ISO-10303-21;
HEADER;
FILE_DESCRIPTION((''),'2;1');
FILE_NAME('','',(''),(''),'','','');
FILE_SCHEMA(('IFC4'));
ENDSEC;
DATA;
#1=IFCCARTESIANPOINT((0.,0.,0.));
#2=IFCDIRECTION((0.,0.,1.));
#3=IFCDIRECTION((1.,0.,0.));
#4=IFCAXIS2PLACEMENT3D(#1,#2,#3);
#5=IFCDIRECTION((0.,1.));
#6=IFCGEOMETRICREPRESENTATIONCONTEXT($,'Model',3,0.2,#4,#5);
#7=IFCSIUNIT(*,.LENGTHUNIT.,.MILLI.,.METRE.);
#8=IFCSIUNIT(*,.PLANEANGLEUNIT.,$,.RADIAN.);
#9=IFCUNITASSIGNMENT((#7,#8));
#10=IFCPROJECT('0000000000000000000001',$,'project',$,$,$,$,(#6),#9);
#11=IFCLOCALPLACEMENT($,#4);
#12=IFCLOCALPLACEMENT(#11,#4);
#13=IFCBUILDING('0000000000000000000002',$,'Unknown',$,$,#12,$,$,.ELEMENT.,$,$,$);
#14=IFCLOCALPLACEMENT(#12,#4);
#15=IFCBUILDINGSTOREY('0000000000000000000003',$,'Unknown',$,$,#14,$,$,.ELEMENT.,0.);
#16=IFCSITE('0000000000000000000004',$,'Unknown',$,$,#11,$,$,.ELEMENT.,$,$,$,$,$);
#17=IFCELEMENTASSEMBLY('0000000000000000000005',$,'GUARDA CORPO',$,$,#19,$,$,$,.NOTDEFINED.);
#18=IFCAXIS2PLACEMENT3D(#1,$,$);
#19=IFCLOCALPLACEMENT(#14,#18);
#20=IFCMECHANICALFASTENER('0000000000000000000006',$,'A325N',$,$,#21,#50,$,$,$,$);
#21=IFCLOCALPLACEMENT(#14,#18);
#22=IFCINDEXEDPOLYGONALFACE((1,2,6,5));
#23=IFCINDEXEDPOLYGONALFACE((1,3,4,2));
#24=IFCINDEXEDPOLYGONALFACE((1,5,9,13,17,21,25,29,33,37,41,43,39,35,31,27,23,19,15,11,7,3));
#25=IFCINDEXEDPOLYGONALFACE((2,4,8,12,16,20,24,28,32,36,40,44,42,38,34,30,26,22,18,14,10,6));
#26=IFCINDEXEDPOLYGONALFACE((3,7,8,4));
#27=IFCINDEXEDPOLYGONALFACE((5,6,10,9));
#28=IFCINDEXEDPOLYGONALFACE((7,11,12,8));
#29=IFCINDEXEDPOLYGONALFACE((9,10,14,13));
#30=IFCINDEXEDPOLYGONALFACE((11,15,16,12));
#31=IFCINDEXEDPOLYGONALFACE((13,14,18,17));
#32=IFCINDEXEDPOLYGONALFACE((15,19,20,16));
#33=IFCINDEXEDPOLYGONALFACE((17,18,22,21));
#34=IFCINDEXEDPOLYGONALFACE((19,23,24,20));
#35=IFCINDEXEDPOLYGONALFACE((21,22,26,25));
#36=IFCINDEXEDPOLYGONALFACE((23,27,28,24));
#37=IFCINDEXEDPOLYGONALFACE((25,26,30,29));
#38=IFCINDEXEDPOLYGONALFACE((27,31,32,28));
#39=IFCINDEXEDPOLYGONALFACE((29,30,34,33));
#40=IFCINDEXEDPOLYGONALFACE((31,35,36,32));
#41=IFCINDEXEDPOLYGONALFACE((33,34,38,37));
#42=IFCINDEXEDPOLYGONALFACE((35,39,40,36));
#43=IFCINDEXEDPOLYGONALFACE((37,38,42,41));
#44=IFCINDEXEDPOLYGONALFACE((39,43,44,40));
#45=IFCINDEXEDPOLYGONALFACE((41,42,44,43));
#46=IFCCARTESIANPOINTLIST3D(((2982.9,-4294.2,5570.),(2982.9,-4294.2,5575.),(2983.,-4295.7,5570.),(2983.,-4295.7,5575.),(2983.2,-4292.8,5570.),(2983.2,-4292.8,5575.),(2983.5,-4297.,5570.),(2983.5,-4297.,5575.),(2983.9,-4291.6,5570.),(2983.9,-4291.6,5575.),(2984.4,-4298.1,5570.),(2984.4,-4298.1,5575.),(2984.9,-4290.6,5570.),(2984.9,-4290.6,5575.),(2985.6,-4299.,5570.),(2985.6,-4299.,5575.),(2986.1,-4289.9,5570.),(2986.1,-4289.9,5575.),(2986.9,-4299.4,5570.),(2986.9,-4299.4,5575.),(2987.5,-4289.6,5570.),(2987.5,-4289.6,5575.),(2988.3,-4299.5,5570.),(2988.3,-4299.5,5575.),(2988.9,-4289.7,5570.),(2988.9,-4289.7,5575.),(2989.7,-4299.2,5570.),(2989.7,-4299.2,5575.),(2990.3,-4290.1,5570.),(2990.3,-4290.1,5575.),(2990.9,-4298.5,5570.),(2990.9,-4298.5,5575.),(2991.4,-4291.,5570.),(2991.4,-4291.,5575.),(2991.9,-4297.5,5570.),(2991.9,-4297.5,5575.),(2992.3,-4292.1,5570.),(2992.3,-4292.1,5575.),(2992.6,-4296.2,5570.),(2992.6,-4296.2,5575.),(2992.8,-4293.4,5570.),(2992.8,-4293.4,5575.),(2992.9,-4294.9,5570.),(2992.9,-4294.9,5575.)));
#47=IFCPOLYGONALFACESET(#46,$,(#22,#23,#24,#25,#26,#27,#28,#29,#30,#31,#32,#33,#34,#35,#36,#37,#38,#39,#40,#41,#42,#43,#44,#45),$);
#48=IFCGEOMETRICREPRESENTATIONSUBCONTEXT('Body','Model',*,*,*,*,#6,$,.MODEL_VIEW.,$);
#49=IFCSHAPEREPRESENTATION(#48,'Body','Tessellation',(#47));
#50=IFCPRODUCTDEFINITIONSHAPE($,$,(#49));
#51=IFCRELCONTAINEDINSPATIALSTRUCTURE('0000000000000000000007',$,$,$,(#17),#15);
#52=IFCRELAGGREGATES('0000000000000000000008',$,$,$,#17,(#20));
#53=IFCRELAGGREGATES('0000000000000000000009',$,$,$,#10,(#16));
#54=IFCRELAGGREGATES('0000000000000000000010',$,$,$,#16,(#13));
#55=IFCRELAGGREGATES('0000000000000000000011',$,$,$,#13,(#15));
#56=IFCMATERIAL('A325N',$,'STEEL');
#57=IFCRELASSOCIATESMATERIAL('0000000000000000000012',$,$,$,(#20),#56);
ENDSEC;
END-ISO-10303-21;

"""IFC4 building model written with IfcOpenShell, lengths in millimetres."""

from ifc_helpers import new_model, si_unit, direction, frame, origin_with_axes, place, context, subcontext, project, spatial, arc, indexed_curve, outline, extrude, source, transform, mapped, material, element, aggregate, save


model = new_model("IFC4")

# Units and contexts
model_context = context("Model", 3, precision=0.2, world=origin_with_axes(), true_north=direction((0.0, 1.0)))
body_context = subcontext(model_context, "Body", "Model", "MODEL_VIEW")
ifc_project = project(units=[si_unit("LENGTHUNIT", "METRE", prefix="MILLI"), si_unit("PLANEANGLEUNIT", "RADIAN")], contexts=[model_context])

# Site, building, storey
site_placement = place(None, origin_with_axes())
site = spatial("IfcSite", under=ifc_project, at=site_placement, Name="Unknown", CompositionType="ELEMENT")
building_placement = place(site_placement, origin_with_axes())
building = spatial("IfcBuilding", under=site, at=building_placement, Name="Unknown", CompositionType="ELEMENT")
storey_placement = place(building_placement, origin_with_axes())
storey = spatial("IfcBuildingStorey", under=building, at=storey_placement, Name="Unknown", CompositionType="ELEMENT", Elevation=0.0)

# Element assembly
assembly_1_placement = place(storey_placement, frame((516.1, -4294.6, 7195.0), z_axis=(0.000512, 1.0, -0.000003), x_axis=(-0.000003, 0.000003, 1.0)))
assembly_1 = element("IfcElementAssembly", 1, at=assembly_1_placement, inside=storey, Name="GUARDA CORPO", PredefinedType="NOTDEFINED")

# Shared definitions
ifc_material_1 = material(Name="A325N", Category="STEEL")

# Mechanical fastener
shared_shape_1 = source(origin_with_axes(), body_context, "Body", "SweptSolid", [
    extrude(outline(indexed_curve([(5.0, 0.0), (0.0, 5.0), (-5.0, 0.0), (0.0, -5.0)], segments=[arc(1, 2, 3), arc(3, 4, 1)])), frame((0.0, 0.0, 0.0), z_axis=(0.0, 0.0, -1.0), x_axis=(0.0, 1.0, 0.0)), (0.0, 0.0, 1.0), 5.0),
])
mechanical_fastener_1_placement = place(assembly_1_placement, frame((-1620.0, 2471.8, 1.4), z_axis=(1.0, 0.000004, -0.000003), x_axis=(0.000005, -0.882404, 0.470493)))
mechanical_fastener_1 = element("IfcMechanicalFastener", 2, at=mechanical_fastener_1_placement, material=ifc_material_1, Name="A325N", context=body_context, shape_type="MappedRepresentation", body=[
    mapped(shared_shape_1, transform((0.0, 0.0, 0.0))),
])
aggregate(assembly_1, [mechanical_fastener_1])

save(model, "model.ifc")
